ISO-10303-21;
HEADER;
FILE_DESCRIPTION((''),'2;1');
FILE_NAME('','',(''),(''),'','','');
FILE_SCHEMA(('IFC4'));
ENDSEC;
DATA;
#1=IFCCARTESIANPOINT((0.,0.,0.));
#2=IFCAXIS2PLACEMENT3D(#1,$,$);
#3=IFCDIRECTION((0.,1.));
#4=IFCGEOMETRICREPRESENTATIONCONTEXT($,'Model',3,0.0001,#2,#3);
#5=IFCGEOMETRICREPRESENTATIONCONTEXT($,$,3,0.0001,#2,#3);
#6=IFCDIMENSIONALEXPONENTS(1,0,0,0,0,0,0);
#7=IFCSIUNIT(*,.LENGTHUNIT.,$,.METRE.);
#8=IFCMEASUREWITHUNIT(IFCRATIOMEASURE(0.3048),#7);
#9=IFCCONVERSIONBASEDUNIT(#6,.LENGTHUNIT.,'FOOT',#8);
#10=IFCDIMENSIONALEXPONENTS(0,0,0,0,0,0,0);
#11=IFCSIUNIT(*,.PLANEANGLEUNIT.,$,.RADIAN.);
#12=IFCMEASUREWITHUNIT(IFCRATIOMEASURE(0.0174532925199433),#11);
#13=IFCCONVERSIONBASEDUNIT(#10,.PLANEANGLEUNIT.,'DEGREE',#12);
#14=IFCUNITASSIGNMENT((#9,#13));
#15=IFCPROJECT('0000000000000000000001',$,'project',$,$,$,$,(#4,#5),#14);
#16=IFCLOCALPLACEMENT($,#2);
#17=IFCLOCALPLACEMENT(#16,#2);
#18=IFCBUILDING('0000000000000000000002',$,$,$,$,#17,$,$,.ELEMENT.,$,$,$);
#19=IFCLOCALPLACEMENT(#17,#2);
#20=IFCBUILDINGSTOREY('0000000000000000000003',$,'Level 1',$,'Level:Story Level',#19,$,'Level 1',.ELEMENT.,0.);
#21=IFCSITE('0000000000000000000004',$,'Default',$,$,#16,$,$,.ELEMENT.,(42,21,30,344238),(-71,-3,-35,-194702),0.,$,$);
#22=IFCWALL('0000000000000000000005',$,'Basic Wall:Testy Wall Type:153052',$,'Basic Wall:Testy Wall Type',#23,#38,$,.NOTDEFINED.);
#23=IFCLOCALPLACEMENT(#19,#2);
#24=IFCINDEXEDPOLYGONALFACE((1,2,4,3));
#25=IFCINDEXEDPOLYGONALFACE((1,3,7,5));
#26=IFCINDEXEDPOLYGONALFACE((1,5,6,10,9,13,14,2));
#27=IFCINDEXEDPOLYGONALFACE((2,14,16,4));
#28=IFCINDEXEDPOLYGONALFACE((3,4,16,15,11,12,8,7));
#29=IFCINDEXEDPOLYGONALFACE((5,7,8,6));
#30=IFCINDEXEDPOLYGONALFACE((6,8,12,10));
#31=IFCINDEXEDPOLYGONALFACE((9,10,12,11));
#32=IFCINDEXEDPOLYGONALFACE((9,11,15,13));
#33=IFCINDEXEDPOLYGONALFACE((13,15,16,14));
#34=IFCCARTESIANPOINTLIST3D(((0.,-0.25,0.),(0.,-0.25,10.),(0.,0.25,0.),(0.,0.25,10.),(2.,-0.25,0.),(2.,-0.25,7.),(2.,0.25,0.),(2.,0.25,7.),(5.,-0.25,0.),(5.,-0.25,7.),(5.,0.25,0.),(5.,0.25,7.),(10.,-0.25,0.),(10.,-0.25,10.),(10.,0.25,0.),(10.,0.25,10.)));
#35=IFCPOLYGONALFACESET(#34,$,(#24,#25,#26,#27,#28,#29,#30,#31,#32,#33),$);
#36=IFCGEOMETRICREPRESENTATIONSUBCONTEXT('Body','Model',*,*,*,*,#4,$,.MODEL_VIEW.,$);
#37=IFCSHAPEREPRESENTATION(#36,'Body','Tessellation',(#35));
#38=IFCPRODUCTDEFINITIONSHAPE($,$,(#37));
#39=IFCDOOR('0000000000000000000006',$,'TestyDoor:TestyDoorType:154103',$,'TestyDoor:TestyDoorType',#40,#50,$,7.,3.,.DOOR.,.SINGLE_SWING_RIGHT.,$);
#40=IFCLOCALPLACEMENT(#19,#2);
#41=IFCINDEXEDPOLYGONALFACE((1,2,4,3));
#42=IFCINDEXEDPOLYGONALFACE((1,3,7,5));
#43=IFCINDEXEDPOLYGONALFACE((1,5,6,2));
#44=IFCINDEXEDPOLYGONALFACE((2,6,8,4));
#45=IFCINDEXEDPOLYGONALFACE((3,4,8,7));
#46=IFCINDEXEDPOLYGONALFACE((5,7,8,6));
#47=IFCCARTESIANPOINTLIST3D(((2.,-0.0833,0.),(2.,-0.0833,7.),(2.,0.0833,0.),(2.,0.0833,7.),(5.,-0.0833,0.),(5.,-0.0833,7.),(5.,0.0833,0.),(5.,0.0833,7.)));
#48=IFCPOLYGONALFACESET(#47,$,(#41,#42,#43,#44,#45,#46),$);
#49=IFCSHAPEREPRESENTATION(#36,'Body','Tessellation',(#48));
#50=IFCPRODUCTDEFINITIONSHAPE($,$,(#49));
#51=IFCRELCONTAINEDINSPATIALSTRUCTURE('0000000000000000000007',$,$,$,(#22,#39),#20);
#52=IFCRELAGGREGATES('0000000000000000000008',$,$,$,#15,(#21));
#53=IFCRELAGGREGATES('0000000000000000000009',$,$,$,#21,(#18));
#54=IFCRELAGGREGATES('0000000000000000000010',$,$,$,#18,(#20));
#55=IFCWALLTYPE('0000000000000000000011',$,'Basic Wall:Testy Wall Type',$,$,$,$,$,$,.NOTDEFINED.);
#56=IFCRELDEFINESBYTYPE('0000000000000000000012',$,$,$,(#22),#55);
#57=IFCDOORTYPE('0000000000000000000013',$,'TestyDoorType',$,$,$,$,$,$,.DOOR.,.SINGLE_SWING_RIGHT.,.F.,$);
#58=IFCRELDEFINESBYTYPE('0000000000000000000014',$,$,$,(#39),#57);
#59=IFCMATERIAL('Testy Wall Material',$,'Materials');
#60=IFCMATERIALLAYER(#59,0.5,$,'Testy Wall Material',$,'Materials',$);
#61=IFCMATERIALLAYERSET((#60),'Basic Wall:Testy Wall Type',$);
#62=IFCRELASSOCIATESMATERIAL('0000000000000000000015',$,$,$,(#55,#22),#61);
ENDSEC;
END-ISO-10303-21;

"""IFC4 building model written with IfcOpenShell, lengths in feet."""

from ifc_helpers import new_model, entity, si_unit, converted_unit, direction, frame, frame_2d, origin, origin_2d_with_axis, place, context, subcontext, project, spatial, rectangle, extrude, source, transform, mapped, material, layer, layer_set, layer_usage, type_object, type_shapes, element, fill, save


model = new_model("IFC4")

# Units and contexts
model_context = context("Model", 3, precision=0.0001, world=origin(), true_north=direction((0.0, 1.0)))
context_of_model = context(None, 3, precision=0.0001, world=origin(), true_north=direction((0.0, 1.0)))
body_context = subcontext(model_context, "Body", "Model", "MODEL_VIEW")
ifc_project = project(units=[converted_unit("LENGTHUNIT", "FOOT", entity("IfcRatioMeasure", 0.3048), si_unit("LENGTHUNIT", "METRE"), dimensions=[1, 0, 0, 0, 0, 0, 0]), converted_unit("PLANEANGLEUNIT", "DEGREE", entity("IfcRatioMeasure", 0.0174532925199433), si_unit("PLANEANGLEUNIT", "RADIAN"), dimensions=[0, 0, 0, 0, 0, 0, 0])], contexts=[model_context, context_of_model])

# Site, building, storey
site_placement = place(None, origin())
site = spatial("IfcSite", under=ifc_project, at=site_placement, Name="Default", CompositionType="ELEMENT", RefLatitude=(42, 21, 30, 344238), RefLongitude=(-71, -3, -35, -194702), RefElevation=0.0)
building_placement = place(site_placement, origin())
building = spatial("IfcBuilding", under=site, at=building_placement, CompositionType="ELEMENT")
storey_placement = place(building_placement, origin())
storey = spatial("IfcBuildingStorey", under=building, at=storey_placement, Name="Level 1", ObjectType="Level:Story Level", LongName="Level 1", CompositionType="ELEMENT", Elevation=0.0)

# Wall, opening, door
ifc_material = material(Name="Testy Wall Material", Category="Materials")
ifc_layer = layer(ifc_material, 0.5, Name="Testy Wall Material", Category="Materials")
ifc_layer_set = layer_set([ifc_layer], Name="Basic Wall:Testy Wall Type")
ifc_layer_usage = layer_usage(ifc_layer_set, "AXIS2", "NEGATIVE", 0.25)
wall_type = type_object("IfcWallType", Name="Basic Wall:Testy Wall Type", PredefinedType="NOTDEFINED", material=ifc_layer_set)
wall_placement = place(storey_placement, origin())
wall = element("IfcWall", 1, at=wall_placement, inside=storey, type_object=wall_type, material=ifc_layer_usage, Name="Basic Wall:Testy Wall Type:153052", ObjectType="Basic Wall:Testy Wall Type", PredefinedType="NOTDEFINED", context=body_context, shape_type="SweptSolid", body=[
    extrude(rectangle(XDim=10.0, YDim=0.5, at=frame_2d((5.0, 0.0), x_axis=(-1.0, 0.0))), origin(), (0.0, 0.0, 1.0), 10.0),
])
opening_placement = place(wall_placement, frame((2.0, -0.25, 0.0)))
opening = element("IfcOpeningElement", 2, at=opening_placement, cuts=wall, ObjectType="Opening", PredefinedType="OPENING", context=body_context, shape_type="SweptSolid", body=[
    extrude(rectangle(XDim=7.0, YDim=3.0, at=frame_2d((3.5, 1.5), x_axis=(1.0, 0.0))), frame((0.0, 0.0, 0.0), z_axis=(0.0, 1.0, 0.0), x_axis=(0.0, 0.0, 1.0)), (0.0, 0.0, 1.0), 0.5),
])
door_type = type_object("IfcDoorType", Name="TestyDoorType", OperationType="SINGLE_SWING_RIGHT", ParameterTakesPrecedence=False, PredefinedType="DOOR")
shared_shape = source(origin(), body_context, "Body", "SweptSolid", [
    extrude(rectangle(XDim=0.1667, YDim=3.0, at=origin_2d_with_axis()), frame((1.5, 0.25, 0.0), z_axis=(0.0, 0.0, 1.0), x_axis=(0.0, 1.0, 0.0)), (0.0, 0.0, 1.0), 7.0),
])
type_shapes(door_type, [shared_shape])
door_placement = place(opening_placement, origin())
door = element("IfcDoor", 3, at=door_placement, inside=storey, type_object=door_type, Name="TestyDoor:TestyDoorType:154103", ObjectType="TestyDoor:TestyDoorType", OperationType="SINGLE_SWING_RIGHT", OverallHeight=7.0, OverallWidth=3.0, PredefinedType="DOOR", context=body_context, shape_type="MappedRepresentation", body=[
    mapped(shared_shape, transform((0.0, 0.0, 0.0), scale=1.0)),
])
fill(opening, door)

save(model, "model.ifc")
